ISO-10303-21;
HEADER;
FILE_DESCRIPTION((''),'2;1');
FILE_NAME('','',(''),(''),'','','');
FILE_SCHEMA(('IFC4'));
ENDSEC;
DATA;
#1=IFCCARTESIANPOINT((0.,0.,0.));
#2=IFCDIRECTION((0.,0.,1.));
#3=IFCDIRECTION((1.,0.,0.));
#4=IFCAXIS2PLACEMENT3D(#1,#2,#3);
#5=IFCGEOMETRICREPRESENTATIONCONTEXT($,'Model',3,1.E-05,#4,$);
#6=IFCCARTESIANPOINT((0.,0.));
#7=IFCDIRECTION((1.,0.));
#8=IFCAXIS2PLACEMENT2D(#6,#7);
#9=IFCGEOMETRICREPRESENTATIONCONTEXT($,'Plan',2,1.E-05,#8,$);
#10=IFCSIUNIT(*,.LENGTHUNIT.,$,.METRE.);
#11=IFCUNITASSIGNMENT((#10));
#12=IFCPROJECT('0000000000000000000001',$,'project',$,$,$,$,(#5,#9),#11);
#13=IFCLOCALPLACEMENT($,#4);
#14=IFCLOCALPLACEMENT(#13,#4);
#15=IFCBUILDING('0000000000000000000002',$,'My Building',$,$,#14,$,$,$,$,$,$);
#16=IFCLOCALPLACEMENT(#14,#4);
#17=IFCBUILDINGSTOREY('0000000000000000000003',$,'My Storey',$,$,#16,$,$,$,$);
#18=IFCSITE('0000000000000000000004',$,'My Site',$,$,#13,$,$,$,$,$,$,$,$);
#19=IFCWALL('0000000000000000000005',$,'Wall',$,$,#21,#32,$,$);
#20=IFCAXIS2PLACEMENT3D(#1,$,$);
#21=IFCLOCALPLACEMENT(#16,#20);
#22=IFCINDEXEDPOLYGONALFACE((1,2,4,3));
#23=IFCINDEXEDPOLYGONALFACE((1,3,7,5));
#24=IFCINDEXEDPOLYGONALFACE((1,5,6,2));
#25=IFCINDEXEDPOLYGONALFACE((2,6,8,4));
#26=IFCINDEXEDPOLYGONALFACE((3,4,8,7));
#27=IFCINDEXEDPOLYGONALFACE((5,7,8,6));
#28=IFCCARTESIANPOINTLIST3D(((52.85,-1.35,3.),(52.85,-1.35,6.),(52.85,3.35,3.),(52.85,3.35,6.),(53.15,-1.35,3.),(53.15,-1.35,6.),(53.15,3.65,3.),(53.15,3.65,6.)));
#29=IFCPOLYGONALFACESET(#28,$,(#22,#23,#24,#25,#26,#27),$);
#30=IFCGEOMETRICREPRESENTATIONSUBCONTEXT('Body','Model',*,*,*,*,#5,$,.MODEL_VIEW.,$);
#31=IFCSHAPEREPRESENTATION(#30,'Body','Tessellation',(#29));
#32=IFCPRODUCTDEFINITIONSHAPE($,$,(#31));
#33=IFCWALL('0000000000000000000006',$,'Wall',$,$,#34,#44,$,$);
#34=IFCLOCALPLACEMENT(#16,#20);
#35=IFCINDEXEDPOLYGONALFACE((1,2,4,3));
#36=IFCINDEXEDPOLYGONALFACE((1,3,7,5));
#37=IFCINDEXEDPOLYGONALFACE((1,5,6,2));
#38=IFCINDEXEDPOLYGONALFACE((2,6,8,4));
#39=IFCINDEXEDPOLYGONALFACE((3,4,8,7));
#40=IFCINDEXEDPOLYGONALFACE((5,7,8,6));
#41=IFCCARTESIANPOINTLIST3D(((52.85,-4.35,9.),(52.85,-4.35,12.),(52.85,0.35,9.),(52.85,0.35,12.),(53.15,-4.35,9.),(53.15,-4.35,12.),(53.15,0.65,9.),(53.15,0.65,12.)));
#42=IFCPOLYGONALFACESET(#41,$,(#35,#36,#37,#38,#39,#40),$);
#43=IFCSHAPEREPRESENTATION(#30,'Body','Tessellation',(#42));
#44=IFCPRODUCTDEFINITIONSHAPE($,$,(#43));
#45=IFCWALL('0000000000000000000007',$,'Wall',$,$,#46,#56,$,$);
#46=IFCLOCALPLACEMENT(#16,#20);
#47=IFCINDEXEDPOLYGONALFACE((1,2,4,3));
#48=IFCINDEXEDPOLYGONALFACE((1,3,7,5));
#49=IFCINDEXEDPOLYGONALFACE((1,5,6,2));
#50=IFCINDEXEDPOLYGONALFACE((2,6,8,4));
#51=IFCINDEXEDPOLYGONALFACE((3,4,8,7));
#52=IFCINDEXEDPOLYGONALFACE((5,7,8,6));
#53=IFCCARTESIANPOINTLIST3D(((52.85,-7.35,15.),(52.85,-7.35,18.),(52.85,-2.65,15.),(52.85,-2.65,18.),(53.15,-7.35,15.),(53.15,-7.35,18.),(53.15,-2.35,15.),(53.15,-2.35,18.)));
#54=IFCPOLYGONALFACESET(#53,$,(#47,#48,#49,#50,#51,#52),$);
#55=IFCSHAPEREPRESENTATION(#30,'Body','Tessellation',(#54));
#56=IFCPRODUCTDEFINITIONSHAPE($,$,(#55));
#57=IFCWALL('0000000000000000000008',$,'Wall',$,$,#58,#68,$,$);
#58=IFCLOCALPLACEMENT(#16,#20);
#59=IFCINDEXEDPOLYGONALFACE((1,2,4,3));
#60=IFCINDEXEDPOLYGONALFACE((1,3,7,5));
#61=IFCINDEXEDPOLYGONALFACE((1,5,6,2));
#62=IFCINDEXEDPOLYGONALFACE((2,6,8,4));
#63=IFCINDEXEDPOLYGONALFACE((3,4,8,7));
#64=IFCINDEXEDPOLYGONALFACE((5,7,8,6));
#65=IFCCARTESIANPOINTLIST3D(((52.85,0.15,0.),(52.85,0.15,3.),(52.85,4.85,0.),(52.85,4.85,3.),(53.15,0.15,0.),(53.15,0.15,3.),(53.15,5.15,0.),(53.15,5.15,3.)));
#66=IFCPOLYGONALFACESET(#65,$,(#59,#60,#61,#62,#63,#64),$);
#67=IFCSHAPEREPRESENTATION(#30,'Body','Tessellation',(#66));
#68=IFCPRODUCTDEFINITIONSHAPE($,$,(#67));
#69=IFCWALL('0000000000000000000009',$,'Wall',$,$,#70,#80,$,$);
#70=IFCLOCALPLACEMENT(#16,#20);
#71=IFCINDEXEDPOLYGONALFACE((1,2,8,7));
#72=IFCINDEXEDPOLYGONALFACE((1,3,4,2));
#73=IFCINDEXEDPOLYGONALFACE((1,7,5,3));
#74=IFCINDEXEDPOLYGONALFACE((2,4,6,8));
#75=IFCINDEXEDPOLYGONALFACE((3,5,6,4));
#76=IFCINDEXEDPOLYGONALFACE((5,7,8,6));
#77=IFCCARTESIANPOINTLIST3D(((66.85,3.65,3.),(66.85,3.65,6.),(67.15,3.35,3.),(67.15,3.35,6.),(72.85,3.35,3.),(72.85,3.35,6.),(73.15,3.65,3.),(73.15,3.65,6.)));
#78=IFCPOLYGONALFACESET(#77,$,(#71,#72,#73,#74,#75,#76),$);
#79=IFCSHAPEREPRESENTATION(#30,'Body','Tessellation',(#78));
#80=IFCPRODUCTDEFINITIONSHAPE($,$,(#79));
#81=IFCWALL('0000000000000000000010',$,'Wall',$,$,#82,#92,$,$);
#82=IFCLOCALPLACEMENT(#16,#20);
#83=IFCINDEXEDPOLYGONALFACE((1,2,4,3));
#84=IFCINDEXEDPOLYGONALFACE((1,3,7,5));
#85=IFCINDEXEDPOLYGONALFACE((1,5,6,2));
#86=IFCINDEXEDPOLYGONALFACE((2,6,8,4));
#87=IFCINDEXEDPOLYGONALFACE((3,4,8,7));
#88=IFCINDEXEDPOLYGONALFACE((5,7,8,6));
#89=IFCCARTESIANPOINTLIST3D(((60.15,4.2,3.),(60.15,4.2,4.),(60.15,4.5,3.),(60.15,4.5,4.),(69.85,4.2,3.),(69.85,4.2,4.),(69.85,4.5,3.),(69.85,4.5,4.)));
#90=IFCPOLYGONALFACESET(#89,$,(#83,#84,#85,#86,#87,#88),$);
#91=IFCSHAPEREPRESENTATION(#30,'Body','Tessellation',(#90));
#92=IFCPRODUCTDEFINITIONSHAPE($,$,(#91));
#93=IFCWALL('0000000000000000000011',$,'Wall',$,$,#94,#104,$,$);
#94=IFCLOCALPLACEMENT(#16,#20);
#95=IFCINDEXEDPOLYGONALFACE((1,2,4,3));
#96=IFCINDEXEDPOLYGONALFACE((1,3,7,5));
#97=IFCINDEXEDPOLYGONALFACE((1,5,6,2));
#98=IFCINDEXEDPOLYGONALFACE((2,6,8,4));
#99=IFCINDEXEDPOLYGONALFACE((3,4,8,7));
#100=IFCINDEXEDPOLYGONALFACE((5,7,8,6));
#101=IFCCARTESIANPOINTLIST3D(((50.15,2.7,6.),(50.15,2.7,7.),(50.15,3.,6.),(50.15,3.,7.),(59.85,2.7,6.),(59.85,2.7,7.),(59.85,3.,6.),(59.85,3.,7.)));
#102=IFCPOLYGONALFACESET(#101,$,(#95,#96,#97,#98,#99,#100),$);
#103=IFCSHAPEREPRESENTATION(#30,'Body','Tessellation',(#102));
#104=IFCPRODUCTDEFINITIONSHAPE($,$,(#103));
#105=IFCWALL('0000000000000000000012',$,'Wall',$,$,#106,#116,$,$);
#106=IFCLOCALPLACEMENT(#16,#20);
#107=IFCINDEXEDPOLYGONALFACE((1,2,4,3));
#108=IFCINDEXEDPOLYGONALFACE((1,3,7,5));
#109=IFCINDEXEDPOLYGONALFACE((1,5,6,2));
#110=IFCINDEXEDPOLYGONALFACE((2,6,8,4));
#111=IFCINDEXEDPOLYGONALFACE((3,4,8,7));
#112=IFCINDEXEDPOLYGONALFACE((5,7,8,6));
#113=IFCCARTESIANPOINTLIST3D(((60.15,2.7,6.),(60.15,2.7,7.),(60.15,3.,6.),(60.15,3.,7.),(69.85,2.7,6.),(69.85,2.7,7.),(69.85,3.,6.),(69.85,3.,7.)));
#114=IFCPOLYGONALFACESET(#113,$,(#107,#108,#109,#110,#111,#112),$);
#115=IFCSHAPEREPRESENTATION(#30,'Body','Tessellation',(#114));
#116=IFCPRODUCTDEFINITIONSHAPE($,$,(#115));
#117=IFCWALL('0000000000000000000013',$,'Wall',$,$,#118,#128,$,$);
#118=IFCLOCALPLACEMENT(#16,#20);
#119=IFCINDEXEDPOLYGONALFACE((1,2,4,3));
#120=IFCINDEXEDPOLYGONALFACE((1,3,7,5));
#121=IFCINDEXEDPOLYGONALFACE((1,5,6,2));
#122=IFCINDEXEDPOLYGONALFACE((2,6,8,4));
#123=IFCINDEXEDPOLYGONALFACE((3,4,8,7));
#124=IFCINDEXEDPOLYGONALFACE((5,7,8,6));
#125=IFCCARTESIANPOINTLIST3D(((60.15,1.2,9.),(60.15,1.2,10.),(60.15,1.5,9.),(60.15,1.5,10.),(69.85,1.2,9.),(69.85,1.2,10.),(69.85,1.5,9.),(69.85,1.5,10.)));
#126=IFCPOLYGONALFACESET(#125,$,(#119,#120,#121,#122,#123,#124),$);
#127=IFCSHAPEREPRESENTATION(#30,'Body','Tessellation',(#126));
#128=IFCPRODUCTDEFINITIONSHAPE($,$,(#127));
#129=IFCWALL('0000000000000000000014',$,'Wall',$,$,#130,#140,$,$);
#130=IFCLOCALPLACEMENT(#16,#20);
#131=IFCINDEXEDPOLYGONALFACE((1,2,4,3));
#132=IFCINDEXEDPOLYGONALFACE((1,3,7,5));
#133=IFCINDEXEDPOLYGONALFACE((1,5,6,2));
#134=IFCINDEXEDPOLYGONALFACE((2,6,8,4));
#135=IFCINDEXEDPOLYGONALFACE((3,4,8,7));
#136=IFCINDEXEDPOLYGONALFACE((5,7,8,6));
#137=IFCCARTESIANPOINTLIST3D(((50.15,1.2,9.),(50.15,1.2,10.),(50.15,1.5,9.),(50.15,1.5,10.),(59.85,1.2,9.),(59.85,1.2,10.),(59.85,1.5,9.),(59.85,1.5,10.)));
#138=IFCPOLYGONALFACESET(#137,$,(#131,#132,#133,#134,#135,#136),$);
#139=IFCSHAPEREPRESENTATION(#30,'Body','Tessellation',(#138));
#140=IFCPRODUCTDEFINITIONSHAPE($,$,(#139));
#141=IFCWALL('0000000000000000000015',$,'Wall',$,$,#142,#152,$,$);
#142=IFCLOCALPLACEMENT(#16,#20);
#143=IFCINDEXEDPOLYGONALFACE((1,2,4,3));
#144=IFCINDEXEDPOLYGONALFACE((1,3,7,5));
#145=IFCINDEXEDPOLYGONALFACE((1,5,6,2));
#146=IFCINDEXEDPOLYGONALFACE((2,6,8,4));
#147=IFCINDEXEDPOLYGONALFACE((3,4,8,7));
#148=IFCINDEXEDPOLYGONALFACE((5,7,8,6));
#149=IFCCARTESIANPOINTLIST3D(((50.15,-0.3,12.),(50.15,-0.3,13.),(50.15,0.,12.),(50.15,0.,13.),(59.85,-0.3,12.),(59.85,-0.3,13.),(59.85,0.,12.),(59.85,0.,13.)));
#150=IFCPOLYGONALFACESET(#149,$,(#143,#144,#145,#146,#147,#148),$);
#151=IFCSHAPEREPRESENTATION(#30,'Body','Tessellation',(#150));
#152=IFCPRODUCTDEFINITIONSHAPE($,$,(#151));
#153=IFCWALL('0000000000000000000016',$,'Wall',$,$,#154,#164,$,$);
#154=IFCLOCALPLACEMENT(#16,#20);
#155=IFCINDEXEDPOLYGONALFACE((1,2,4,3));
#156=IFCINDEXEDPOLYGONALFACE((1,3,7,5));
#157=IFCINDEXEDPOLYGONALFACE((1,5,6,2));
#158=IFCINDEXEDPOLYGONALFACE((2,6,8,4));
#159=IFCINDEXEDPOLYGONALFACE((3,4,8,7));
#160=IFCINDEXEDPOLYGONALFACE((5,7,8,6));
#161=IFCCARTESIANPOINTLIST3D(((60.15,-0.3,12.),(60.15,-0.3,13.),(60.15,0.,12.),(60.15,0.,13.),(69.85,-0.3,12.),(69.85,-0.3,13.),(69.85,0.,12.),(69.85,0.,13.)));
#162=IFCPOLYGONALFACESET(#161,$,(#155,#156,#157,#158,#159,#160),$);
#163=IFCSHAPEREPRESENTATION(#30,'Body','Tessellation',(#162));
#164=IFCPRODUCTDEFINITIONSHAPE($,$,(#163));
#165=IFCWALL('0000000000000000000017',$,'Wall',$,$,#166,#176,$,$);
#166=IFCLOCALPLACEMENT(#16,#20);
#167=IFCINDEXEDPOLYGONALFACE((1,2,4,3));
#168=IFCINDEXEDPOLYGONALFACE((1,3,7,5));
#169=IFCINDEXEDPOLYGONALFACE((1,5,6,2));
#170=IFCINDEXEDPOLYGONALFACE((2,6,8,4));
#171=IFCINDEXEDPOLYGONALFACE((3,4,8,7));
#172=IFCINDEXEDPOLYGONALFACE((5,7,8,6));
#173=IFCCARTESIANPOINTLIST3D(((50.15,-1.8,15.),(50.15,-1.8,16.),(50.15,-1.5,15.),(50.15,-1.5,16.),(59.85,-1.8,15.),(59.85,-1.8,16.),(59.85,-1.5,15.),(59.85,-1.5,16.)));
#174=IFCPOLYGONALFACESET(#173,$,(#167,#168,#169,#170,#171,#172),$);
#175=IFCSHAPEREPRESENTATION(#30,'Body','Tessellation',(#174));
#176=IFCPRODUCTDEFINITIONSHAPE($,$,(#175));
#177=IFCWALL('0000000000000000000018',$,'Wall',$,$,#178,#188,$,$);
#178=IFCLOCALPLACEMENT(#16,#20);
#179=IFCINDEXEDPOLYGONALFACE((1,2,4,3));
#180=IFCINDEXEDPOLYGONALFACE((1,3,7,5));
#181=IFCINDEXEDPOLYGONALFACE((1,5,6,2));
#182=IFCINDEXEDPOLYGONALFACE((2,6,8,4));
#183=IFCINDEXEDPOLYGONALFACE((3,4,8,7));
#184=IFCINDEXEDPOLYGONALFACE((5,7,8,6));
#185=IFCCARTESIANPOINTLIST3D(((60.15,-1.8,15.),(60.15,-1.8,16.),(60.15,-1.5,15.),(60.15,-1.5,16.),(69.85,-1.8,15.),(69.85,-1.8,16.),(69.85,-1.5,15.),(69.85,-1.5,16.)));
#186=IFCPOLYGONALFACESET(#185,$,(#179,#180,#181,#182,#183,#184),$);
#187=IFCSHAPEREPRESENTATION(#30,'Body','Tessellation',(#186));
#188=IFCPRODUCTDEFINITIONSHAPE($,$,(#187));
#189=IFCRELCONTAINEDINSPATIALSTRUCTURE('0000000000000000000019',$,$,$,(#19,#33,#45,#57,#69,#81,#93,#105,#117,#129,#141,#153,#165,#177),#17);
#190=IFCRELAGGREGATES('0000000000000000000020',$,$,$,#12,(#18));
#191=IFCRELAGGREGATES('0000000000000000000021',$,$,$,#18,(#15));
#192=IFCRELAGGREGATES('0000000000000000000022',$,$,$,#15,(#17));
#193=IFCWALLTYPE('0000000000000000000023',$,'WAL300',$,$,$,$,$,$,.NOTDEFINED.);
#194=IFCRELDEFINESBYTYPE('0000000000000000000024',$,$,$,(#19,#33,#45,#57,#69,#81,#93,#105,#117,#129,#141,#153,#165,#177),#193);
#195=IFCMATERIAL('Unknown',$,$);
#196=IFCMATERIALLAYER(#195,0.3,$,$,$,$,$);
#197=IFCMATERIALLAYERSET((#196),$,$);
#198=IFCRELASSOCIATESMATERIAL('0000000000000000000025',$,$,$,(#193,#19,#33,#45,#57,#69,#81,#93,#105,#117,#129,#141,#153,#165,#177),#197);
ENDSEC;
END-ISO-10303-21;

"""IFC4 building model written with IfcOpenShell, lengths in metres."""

from ifc_helpers import new_model, si_unit, frame, origin_with_axes, origin_2d_with_axis, place, context, subcontext, project, spatial, line, indexed_curve, outline, extrude, material, layer, layer_set, layer_usage, type_object, element, save


model = new_model("IFC4")

# Units and contexts
model_context = context("Model", 3, precision=1e-05, world=origin_with_axes())
plan_context = context("Plan", 2, precision=1e-05, world=origin_2d_with_axis())
body_context = subcontext(model_context, "Body", "Model", "MODEL_VIEW")
ifc_project = project(units=[si_unit("LENGTHUNIT", "METRE")], contexts=[model_context, plan_context])

# Site, building, storey
site_placement = place(None, origin_with_axes())
site = spatial("IfcSite", under=ifc_project, at=site_placement, Name="My Site")
building_placement = place(site_placement, origin_with_axes())
building = spatial("IfcBuilding", under=site, at=building_placement, Name="My Building")
storey_placement = place(building_placement, origin_with_axes())
storey = spatial("IfcBuildingStorey", under=building, at=storey_placement, Name="My Storey")

# Walls
ifc_material = material(Name="Unknown")
ifc_layer = layer(ifc_material, 0.3)
ifc_layer_set = layer_set([ifc_layer])
wall_type = type_object("IfcWallType", Name="WAL300", PredefinedType="NOTDEFINED", material=ifc_layer_set)
ifc_layer_usage_1 = layer_usage(ifc_layer_set, "AXIS2", "POSITIVE", -0.15)
wall_1_placement = place(storey_placement, frame((53.0, -1.5, 3.0), z_axis=(0.0, 0.0, 1.0), x_axis=(0.0, 1.0, 0.0)))
element("IfcWall", 1, at=wall_1_placement, inside=storey, type_object=wall_type, material=ifc_layer_usage_1, Name="Wall", context=body_context, shape_type="SweptSolid", body=[
    extrude(outline(indexed_curve([(0.15, -0.15), (0.15, 0.15), (4.85, 0.15), (5.15, -0.15)], segments=[line(1, 2, 3, 4, 1)])), origin_with_axes(), (0.0, 0.0, 1.0), 3.0),
])
ifc_layer_usage_2 = layer_usage(ifc_layer_set, "AXIS2", "POSITIVE", -0.15)
wall_2_placement = place(storey_placement, frame((53.0, -4.5, 9.0), z_axis=(0.0, 0.0, 1.0), x_axis=(0.0, 1.0, 0.0)))
element("IfcWall", 2, at=wall_2_placement, inside=storey, type_object=wall_type, material=ifc_layer_usage_2, Name="Wall", context=body_context, shape_type="SweptSolid", body=[
    extrude(outline(indexed_curve([(0.15, -0.15), (0.15, 0.15), (4.85, 0.15), (5.15, -0.15)], segments=[line(1, 2, 3, 4, 1)])), origin_with_axes(), (0.0, 0.0, 1.0), 3.0),
])
ifc_layer_usage_3 = layer_usage(ifc_layer_set, "AXIS2", "POSITIVE", -0.15)
wall_3_placement = place(storey_placement, frame((53.0, -7.5, 15.0), z_axis=(0.0, 0.0, 1.0), x_axis=(0.0, 1.0, 0.0)))
element("IfcWall", 3, at=wall_3_placement, inside=storey, type_object=wall_type, material=ifc_layer_usage_3, Name="Wall", context=body_context, shape_type="SweptSolid", body=[
    extrude(outline(indexed_curve([(0.15, -0.15), (0.15, 0.15), (4.85, 0.15), (5.15, -0.15)], segments=[line(1, 2, 3, 4, 1)])), origin_with_axes(), (0.0, 0.0, 1.0), 3.0),
])
ifc_layer_usage_4 = layer_usage(ifc_layer_set, "AXIS2", "POSITIVE", -0.15)
wall_4_placement = place(storey_placement, frame((53.0, 0.0, 0.0), z_axis=(0.0, 0.0, 1.0), x_axis=(0.0, 1.0, 0.0)))
element("IfcWall", 4, at=wall_4_placement, inside=storey, type_object=wall_type, material=ifc_layer_usage_4, Name="Wall", context=body_context, shape_type="SweptSolid", body=[
    extrude(outline(indexed_curve([(0.15, -0.15), (0.15, 0.15), (4.85, 0.15), (5.15, -0.15)], segments=[line(1, 2, 3, 4, 1)])), origin_with_axes(), (0.0, 0.0, 1.0), 3.0),
])
ifc_layer_usage_5 = layer_usage(ifc_layer_set, "AXIS2", "POSITIVE", -0.15)
wall_5_placement = place(storey_placement, frame((67.0, 3.5, 3.0), z_axis=(0.0, 0.0, 1.0), x_axis=(1.0, 0.0, 0.0)))
element("IfcWall", 5, at=wall_5_placement, inside=storey, type_object=wall_type, material=ifc_layer_usage_5, Name="Wall", context=body_context, shape_type="SweptSolid", body=[
    extrude(outline(indexed_curve([(0.15, -0.15), (-0.15, 0.15), (6.15, 0.15), (5.85, -0.15)], segments=[line(1, 2, 3, 4, 1)])), origin_with_axes(), (0.0, 0.0, 1.0), 3.0),
])
ifc_layer_usage_6 = layer_usage(ifc_layer_set, "AXIS2", "POSITIVE", -0.3)
wall_6_placement = place(storey_placement, frame((60.15, 4.5, 3.0), z_axis=(0.0, 0.0, 1.0), x_axis=(1.0, 0.0, 0.0)))
element("IfcWall", 6, at=wall_6_placement, inside=storey, type_object=wall_type, material=ifc_layer_usage_6, Name="Wall", context=body_context, shape_type="SweptSolid", body=[
    extrude(outline(indexed_curve([(0.0, -0.3), (0.0, 0.0), (9.7, 0.0), (9.7, -0.3)], segments=[line(1, 2, 3, 4, 1)])), origin_with_axes(), (0.0, 0.0, 1.0), 1.0),
])
ifc_layer_usage_7 = layer_usage(ifc_layer_set, "AXIS2", "POSITIVE", -0.3)
wall_7_placement = place(storey_placement, frame((50.15, 3.0, 6.0), z_axis=(0.0, 0.0, 1.0), x_axis=(1.0, 0.0, 0.0)))
element("IfcWall", 7, at=wall_7_placement, inside=storey, type_object=wall_type, material=ifc_layer_usage_7, Name="Wall", context=body_context, shape_type="SweptSolid", body=[
    extrude(outline(indexed_curve([(0.0, -0.3), (0.0, 0.0), (9.7, 0.0), (9.7, -0.3)], segments=[line(1, 2, 3, 4, 1)])), origin_with_axes(), (0.0, 0.0, 1.0), 1.0),
])
ifc_layer_usage_8 = layer_usage(ifc_layer_set, "AXIS2", "POSITIVE", -0.3)
wall_8_placement = place(storey_placement, frame((60.15, 3.0, 6.0), z_axis=(0.0, 0.0, 1.0), x_axis=(1.0, 0.0, 0.0)))
element("IfcWall", 8, at=wall_8_placement, inside=storey, type_object=wall_type, material=ifc_layer_usage_8, Name="Wall", context=body_context, shape_type="SweptSolid", body=[
    extrude(outline(indexed_curve([(0.0, -0.3), (0.0, 0.0), (9.7, 0.0), (9.7, -0.3)], segments=[line(1, 2, 3, 4, 1)])), origin_with_axes(), (0.0, 0.0, 1.0), 1.0),
])
ifc_layer_usage_9 = layer_usage(ifc_layer_set, "AXIS2", "POSITIVE", -0.3)
wall_9_placement = place(storey_placement, frame((60.15, 1.5, 9.0), z_axis=(0.0, 0.0, 1.0), x_axis=(1.0, 0.0, 0.0)))
element("IfcWall", 9, at=wall_9_placement, inside=storey, type_object=wall_type, material=ifc_layer_usage_9, Name="Wall", context=body_context, shape_type="SweptSolid", body=[
    extrude(outline(indexed_curve([(0.0, -0.3), (0.0, 0.0), (9.7, 0.0), (9.7, -0.3)], segments=[line(1, 2, 3, 4, 1)])), origin_with_axes(), (0.0, 0.0, 1.0), 1.0),
])
ifc_layer_usage_10 = layer_usage(ifc_layer_set, "AXIS2", "POSITIVE", -0.3)
wall_10_placement = place(storey_placement, frame((50.15, 1.5, 9.0), z_axis=(0.0, 0.0, 1.0), x_axis=(1.0, 0.0, 0.0)))
element("IfcWall", 10, at=wall_10_placement, inside=storey, type_object=wall_type, material=ifc_layer_usage_10, Name="Wall", context=body_context, shape_type="SweptSolid", body=[
    extrude(outline(indexed_curve([(0.0, -0.3), (0.0, 0.0), (9.7, 0.0), (9.7, -0.3)], segments=[line(1, 2, 3, 4, 1)])), origin_with_axes(), (0.0, 0.0, 1.0), 1.0),
])
ifc_layer_usage_11 = layer_usage(ifc_layer_set, "AXIS2", "POSITIVE", -0.3)
wall_11_placement = place(storey_placement, frame((50.15, 0.0, 12.0), z_axis=(0.0, 0.0, 1.0), x_axis=(1.0, 0.0, 0.0)))
element("IfcWall", 11, at=wall_11_placement, inside=storey, type_object=wall_type, material=ifc_layer_usage_11, Name="Wall", context=body_context, shape_type="SweptSolid", body=[
    extrude(outline(indexed_curve([(0.0, -0.3), (0.0, 0.0), (9.7, 0.0), (9.7, -0.3)], segments=[line(1, 2, 3, 4, 1)])), origin_with_axes(), (0.0, 0.0, 1.0), 1.0),
])
ifc_layer_usage_12 = layer_usage(ifc_layer_set, "AXIS2", "POSITIVE", -0.3)
wall_12_placement = place(storey_placement, frame((60.15, 0.0, 12.0), z_axis=(0.0, 0.0, 1.0), x_axis=(1.0, 0.0, 0.0)))
element("IfcWall", 12, at=wall_12_placement, inside=storey, type_object=wall_type, material=ifc_layer_usage_12, Name="Wall", context=body_context, shape_type="SweptSolid", body=[
    extrude(outline(indexed_curve([(0.0, -0.3), (0.0, 0.0), (9.7, 0.0), (9.7, -0.3)], segments=[line(1, 2, 3, 4, 1)])), origin_with_axes(), (0.0, 0.0, 1.0), 1.0),
])
ifc_layer_usage_13 = layer_usage(ifc_layer_set, "AXIS2", "POSITIVE", -0.3)
wall_13_placement = place(storey_placement, frame((50.15, -1.5, 15.0), z_axis=(0.0, 0.0, 1.0), x_axis=(1.0, 0.0, 0.0)))
element("IfcWall", 13, at=wall_13_placement, inside=storey, type_object=wall_type, material=ifc_layer_usage_13, Name="Wall", context=body_context, shape_type="SweptSolid", body=[
    extrude(outline(indexed_curve([(0.0, -0.3), (0.0, 0.0), (9.7, 0.0), (9.7, -0.3)], segments=[line(1, 2, 3, 4, 1)])), origin_with_axes(), (0.0, 0.0, 1.0), 1.0),
])
ifc_layer_usage_14 = layer_usage(ifc_layer_set, "AXIS2", "POSITIVE", -0.3)
wall_14_placement = place(storey_placement, frame((60.15, -1.5, 15.0), z_axis=(0.0, 0.0, 1.0), x_axis=(1.0, 0.0, 0.0)))
element("IfcWall", 14, at=wall_14_placement, inside=storey, type_object=wall_type, material=ifc_layer_usage_14, Name="Wall", context=body_context, shape_type="SweptSolid", body=[
    extrude(outline(indexed_curve([(0.0, -0.3), (0.0, 0.0), (9.7, 0.0), (9.7, -0.3)], segments=[line(1, 2, 3, 4, 1)])), origin_with_axes(), (0.0, 0.0, 1.0), 1.0),
])

save(model, "model.ifc")
